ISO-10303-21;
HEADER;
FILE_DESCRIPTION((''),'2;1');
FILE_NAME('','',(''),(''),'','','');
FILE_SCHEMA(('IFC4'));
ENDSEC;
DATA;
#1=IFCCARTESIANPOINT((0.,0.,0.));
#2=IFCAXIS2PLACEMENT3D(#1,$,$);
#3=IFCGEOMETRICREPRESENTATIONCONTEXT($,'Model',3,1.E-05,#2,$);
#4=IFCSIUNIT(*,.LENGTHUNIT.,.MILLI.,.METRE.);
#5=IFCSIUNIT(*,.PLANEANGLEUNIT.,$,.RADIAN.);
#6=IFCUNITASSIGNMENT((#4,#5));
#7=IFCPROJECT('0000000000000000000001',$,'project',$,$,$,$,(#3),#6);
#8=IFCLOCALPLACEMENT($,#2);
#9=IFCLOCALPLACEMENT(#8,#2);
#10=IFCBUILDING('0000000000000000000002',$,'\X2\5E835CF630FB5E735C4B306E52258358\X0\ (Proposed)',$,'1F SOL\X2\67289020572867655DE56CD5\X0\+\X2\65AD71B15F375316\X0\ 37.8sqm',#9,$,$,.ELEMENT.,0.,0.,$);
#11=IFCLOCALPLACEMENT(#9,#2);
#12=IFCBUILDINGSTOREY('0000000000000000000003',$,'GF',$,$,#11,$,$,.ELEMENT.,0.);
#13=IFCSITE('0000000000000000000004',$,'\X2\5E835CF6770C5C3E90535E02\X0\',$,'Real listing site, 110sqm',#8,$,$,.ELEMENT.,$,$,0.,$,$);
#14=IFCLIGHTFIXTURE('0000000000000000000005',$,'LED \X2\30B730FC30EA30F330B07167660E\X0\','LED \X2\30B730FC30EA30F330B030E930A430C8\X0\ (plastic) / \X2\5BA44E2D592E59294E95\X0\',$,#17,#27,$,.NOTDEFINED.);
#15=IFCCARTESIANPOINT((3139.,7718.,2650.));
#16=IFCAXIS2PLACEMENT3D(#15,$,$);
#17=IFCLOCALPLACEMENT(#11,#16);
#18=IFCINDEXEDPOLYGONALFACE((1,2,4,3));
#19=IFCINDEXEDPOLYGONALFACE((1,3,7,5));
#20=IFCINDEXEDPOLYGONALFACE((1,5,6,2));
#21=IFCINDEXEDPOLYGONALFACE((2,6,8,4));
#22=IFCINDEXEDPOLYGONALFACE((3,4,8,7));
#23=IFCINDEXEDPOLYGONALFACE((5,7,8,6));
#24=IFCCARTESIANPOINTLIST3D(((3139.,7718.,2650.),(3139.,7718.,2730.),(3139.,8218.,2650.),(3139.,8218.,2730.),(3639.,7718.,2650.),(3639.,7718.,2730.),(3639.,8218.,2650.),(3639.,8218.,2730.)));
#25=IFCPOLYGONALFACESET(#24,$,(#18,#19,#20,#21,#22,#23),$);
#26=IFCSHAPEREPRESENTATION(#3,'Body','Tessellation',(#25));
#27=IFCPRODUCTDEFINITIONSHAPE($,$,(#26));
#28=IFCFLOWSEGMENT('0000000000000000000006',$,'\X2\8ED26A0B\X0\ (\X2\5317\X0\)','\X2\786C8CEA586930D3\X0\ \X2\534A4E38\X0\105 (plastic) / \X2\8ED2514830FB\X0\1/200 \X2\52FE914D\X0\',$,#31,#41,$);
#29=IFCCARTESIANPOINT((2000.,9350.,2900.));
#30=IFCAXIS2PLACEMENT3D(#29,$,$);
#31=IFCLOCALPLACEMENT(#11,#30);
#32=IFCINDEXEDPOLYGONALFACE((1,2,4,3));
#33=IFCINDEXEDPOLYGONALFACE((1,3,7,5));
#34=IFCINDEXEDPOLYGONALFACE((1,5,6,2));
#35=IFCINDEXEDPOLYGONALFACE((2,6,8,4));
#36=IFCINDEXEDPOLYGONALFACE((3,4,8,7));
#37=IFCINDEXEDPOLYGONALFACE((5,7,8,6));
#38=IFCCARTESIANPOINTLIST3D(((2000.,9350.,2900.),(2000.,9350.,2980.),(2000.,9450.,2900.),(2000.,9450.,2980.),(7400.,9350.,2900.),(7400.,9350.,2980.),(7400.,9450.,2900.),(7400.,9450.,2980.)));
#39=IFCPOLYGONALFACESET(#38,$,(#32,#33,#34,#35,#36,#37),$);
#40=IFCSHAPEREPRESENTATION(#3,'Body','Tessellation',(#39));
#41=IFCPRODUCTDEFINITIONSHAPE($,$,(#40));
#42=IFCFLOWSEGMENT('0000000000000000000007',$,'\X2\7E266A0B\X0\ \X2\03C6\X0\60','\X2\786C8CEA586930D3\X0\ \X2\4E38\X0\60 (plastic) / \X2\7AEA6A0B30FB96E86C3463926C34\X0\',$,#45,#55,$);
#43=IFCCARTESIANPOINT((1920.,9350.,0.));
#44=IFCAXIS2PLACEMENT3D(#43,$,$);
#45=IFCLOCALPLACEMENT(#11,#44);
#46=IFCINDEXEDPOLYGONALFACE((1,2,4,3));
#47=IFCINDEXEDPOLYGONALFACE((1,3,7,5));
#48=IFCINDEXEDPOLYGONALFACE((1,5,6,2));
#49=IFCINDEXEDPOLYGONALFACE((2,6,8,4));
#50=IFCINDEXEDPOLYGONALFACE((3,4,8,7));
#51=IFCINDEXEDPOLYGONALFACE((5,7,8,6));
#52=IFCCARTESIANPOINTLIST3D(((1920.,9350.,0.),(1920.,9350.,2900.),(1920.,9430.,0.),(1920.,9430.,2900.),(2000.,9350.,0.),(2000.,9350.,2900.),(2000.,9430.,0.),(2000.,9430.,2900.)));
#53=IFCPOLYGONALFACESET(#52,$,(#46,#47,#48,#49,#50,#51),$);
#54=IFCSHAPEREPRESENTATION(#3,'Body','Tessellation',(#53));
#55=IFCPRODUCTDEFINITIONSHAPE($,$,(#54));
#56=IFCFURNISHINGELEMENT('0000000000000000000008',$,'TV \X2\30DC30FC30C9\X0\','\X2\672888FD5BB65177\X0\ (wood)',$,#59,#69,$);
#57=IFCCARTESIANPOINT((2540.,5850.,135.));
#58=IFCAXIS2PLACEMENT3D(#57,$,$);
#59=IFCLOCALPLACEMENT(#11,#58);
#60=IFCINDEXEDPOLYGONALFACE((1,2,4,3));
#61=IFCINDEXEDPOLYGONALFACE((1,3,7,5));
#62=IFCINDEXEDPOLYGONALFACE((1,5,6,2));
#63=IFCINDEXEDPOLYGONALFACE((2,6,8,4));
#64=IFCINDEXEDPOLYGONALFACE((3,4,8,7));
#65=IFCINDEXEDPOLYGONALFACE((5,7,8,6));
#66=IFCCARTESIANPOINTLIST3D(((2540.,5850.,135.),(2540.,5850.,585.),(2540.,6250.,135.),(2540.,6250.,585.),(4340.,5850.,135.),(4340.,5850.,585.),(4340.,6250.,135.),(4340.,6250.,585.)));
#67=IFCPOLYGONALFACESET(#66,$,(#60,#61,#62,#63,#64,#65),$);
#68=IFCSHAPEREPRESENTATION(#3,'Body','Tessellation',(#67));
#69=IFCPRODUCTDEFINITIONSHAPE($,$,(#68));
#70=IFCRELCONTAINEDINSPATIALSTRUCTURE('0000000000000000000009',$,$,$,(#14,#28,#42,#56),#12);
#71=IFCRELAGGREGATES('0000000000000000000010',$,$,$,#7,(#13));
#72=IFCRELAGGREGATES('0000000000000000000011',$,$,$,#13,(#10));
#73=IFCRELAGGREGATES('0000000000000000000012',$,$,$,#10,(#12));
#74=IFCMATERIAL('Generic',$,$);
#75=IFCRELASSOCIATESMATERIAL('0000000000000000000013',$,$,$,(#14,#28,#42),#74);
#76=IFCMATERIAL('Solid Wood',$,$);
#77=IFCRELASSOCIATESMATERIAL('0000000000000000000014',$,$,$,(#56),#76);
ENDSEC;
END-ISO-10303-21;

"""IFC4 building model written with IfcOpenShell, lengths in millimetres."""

from ifc_helpers import new_model, si_unit, frame, frame_2d, origin, place, context, project, spatial, rectangle, extrude, material, element, save


model = new_model("IFC4")

# Units and contexts
model_context = context("Model", 3, precision=1e-05, world=origin())
ifc_project = project(units=[si_unit("LENGTHUNIT", "METRE", prefix="MILLI"), si_unit("PLANEANGLEUNIT", "RADIAN")], contexts=[model_context])

# Site, building, storey
site_placement = place(None, origin())
site = spatial("IfcSite", under=ifc_project, at=site_placement, Name="広島県尾道市", ObjectType="Real listing site, 110sqm", CompositionType="ELEMENT", RefElevation=0.0)
building_placement = place(site_placement, origin())
building = spatial("IfcBuilding", under=site, at=building_placement, Name="広島・平屋の別荘 (Proposed)", ObjectType="1F SOL木造在来工法+断熱強化 37.8sqm", CompositionType="ELEMENT", ElevationOfRefHeight=0.0, ElevationOfTerrain=0.0)
storey_placement = place(building_placement, origin())
storey = spatial("IfcBuildingStorey", under=building, at=storey_placement, Name="GF", CompositionType="ELEMENT", Elevation=0.0)

# Shared definitions
ifc_material_1 = material(Name="Solid Wood")

# Shared definitions
ifc_material_2 = material(Name="Generic")

# Light fixture
light_fixture_placement = place(storey_placement, frame((3139.0, 7718.0, 2650.0)))
element("IfcLightFixture", 1, at=light_fixture_placement, inside=storey, material=ifc_material_2, Name="LED シーリング照明", Description="LED シーリングライト (plastic) / 室中央天井", PredefinedType="NOTDEFINED", context=model_context, shape_type="SweptSolid", body=[
    extrude(rectangle(XDim=500.0, YDim=500.0, at=frame_2d((250.0, 250.0))), frame((3139.0, 7718.0, 2650.0)), (0.0, 0.0, 1.0), 80.0),
])

# Flow segments
flow_segment_1_placement = place(storey_placement, frame((2000.0, 9350.0, 2900.0)))
element("IfcFlowSegment", 2, at=flow_segment_1_placement, inside=storey, material=ifc_material_2, Name="軒樋 (北)", Description="硬質塩ビ 半丸105 (plastic) / 軒先・1/200 勾配", context=model_context, shape_type="SweptSolid", body=[
    extrude(rectangle(XDim=5400.0, YDim=100.0, at=frame_2d((2700.0, 50.0))), frame((2000.0, 9350.0, 2900.0)), (0.0, 0.0, 1.0), 80.0),
])
flow_segment_2_placement = place(storey_placement, frame((1920.0, 9350.0, 0.0)))
element("IfcFlowSegment", 3, at=flow_segment_2_placement, inside=storey, material=ifc_material_2, Name="縦樋 φ60", Description="硬質塩ビ 丸60 (plastic) / 竪樋・雨水排水", context=model_context, shape_type="SweptSolid", body=[
    extrude(rectangle(XDim=80.0, YDim=80.0, at=frame_2d((40.0, 40.0))), frame((1920.0, 9350.0, 0.0)), (0.0, 0.0, 1.0), 2900.0),
])

# Furnishing element
furnishing_placement = place(storey_placement, frame((2540.0, 5850.0, 135.0)))
element("IfcFurnishingElement", 4, at=furnishing_placement, inside=storey, material=ifc_material_1, Name="TV ボード", Description="木製家具 (wood)", context=model_context, shape_type="SweptSolid", body=[
    extrude(rectangle(XDim=1800.0, YDim=400.0, at=frame_2d((900.0, 200.0))), frame((2540.0, 5850.0, 135.0)), (0.0, 0.0, 1.0), 450.0),
])

save(model, "model.ifc")
